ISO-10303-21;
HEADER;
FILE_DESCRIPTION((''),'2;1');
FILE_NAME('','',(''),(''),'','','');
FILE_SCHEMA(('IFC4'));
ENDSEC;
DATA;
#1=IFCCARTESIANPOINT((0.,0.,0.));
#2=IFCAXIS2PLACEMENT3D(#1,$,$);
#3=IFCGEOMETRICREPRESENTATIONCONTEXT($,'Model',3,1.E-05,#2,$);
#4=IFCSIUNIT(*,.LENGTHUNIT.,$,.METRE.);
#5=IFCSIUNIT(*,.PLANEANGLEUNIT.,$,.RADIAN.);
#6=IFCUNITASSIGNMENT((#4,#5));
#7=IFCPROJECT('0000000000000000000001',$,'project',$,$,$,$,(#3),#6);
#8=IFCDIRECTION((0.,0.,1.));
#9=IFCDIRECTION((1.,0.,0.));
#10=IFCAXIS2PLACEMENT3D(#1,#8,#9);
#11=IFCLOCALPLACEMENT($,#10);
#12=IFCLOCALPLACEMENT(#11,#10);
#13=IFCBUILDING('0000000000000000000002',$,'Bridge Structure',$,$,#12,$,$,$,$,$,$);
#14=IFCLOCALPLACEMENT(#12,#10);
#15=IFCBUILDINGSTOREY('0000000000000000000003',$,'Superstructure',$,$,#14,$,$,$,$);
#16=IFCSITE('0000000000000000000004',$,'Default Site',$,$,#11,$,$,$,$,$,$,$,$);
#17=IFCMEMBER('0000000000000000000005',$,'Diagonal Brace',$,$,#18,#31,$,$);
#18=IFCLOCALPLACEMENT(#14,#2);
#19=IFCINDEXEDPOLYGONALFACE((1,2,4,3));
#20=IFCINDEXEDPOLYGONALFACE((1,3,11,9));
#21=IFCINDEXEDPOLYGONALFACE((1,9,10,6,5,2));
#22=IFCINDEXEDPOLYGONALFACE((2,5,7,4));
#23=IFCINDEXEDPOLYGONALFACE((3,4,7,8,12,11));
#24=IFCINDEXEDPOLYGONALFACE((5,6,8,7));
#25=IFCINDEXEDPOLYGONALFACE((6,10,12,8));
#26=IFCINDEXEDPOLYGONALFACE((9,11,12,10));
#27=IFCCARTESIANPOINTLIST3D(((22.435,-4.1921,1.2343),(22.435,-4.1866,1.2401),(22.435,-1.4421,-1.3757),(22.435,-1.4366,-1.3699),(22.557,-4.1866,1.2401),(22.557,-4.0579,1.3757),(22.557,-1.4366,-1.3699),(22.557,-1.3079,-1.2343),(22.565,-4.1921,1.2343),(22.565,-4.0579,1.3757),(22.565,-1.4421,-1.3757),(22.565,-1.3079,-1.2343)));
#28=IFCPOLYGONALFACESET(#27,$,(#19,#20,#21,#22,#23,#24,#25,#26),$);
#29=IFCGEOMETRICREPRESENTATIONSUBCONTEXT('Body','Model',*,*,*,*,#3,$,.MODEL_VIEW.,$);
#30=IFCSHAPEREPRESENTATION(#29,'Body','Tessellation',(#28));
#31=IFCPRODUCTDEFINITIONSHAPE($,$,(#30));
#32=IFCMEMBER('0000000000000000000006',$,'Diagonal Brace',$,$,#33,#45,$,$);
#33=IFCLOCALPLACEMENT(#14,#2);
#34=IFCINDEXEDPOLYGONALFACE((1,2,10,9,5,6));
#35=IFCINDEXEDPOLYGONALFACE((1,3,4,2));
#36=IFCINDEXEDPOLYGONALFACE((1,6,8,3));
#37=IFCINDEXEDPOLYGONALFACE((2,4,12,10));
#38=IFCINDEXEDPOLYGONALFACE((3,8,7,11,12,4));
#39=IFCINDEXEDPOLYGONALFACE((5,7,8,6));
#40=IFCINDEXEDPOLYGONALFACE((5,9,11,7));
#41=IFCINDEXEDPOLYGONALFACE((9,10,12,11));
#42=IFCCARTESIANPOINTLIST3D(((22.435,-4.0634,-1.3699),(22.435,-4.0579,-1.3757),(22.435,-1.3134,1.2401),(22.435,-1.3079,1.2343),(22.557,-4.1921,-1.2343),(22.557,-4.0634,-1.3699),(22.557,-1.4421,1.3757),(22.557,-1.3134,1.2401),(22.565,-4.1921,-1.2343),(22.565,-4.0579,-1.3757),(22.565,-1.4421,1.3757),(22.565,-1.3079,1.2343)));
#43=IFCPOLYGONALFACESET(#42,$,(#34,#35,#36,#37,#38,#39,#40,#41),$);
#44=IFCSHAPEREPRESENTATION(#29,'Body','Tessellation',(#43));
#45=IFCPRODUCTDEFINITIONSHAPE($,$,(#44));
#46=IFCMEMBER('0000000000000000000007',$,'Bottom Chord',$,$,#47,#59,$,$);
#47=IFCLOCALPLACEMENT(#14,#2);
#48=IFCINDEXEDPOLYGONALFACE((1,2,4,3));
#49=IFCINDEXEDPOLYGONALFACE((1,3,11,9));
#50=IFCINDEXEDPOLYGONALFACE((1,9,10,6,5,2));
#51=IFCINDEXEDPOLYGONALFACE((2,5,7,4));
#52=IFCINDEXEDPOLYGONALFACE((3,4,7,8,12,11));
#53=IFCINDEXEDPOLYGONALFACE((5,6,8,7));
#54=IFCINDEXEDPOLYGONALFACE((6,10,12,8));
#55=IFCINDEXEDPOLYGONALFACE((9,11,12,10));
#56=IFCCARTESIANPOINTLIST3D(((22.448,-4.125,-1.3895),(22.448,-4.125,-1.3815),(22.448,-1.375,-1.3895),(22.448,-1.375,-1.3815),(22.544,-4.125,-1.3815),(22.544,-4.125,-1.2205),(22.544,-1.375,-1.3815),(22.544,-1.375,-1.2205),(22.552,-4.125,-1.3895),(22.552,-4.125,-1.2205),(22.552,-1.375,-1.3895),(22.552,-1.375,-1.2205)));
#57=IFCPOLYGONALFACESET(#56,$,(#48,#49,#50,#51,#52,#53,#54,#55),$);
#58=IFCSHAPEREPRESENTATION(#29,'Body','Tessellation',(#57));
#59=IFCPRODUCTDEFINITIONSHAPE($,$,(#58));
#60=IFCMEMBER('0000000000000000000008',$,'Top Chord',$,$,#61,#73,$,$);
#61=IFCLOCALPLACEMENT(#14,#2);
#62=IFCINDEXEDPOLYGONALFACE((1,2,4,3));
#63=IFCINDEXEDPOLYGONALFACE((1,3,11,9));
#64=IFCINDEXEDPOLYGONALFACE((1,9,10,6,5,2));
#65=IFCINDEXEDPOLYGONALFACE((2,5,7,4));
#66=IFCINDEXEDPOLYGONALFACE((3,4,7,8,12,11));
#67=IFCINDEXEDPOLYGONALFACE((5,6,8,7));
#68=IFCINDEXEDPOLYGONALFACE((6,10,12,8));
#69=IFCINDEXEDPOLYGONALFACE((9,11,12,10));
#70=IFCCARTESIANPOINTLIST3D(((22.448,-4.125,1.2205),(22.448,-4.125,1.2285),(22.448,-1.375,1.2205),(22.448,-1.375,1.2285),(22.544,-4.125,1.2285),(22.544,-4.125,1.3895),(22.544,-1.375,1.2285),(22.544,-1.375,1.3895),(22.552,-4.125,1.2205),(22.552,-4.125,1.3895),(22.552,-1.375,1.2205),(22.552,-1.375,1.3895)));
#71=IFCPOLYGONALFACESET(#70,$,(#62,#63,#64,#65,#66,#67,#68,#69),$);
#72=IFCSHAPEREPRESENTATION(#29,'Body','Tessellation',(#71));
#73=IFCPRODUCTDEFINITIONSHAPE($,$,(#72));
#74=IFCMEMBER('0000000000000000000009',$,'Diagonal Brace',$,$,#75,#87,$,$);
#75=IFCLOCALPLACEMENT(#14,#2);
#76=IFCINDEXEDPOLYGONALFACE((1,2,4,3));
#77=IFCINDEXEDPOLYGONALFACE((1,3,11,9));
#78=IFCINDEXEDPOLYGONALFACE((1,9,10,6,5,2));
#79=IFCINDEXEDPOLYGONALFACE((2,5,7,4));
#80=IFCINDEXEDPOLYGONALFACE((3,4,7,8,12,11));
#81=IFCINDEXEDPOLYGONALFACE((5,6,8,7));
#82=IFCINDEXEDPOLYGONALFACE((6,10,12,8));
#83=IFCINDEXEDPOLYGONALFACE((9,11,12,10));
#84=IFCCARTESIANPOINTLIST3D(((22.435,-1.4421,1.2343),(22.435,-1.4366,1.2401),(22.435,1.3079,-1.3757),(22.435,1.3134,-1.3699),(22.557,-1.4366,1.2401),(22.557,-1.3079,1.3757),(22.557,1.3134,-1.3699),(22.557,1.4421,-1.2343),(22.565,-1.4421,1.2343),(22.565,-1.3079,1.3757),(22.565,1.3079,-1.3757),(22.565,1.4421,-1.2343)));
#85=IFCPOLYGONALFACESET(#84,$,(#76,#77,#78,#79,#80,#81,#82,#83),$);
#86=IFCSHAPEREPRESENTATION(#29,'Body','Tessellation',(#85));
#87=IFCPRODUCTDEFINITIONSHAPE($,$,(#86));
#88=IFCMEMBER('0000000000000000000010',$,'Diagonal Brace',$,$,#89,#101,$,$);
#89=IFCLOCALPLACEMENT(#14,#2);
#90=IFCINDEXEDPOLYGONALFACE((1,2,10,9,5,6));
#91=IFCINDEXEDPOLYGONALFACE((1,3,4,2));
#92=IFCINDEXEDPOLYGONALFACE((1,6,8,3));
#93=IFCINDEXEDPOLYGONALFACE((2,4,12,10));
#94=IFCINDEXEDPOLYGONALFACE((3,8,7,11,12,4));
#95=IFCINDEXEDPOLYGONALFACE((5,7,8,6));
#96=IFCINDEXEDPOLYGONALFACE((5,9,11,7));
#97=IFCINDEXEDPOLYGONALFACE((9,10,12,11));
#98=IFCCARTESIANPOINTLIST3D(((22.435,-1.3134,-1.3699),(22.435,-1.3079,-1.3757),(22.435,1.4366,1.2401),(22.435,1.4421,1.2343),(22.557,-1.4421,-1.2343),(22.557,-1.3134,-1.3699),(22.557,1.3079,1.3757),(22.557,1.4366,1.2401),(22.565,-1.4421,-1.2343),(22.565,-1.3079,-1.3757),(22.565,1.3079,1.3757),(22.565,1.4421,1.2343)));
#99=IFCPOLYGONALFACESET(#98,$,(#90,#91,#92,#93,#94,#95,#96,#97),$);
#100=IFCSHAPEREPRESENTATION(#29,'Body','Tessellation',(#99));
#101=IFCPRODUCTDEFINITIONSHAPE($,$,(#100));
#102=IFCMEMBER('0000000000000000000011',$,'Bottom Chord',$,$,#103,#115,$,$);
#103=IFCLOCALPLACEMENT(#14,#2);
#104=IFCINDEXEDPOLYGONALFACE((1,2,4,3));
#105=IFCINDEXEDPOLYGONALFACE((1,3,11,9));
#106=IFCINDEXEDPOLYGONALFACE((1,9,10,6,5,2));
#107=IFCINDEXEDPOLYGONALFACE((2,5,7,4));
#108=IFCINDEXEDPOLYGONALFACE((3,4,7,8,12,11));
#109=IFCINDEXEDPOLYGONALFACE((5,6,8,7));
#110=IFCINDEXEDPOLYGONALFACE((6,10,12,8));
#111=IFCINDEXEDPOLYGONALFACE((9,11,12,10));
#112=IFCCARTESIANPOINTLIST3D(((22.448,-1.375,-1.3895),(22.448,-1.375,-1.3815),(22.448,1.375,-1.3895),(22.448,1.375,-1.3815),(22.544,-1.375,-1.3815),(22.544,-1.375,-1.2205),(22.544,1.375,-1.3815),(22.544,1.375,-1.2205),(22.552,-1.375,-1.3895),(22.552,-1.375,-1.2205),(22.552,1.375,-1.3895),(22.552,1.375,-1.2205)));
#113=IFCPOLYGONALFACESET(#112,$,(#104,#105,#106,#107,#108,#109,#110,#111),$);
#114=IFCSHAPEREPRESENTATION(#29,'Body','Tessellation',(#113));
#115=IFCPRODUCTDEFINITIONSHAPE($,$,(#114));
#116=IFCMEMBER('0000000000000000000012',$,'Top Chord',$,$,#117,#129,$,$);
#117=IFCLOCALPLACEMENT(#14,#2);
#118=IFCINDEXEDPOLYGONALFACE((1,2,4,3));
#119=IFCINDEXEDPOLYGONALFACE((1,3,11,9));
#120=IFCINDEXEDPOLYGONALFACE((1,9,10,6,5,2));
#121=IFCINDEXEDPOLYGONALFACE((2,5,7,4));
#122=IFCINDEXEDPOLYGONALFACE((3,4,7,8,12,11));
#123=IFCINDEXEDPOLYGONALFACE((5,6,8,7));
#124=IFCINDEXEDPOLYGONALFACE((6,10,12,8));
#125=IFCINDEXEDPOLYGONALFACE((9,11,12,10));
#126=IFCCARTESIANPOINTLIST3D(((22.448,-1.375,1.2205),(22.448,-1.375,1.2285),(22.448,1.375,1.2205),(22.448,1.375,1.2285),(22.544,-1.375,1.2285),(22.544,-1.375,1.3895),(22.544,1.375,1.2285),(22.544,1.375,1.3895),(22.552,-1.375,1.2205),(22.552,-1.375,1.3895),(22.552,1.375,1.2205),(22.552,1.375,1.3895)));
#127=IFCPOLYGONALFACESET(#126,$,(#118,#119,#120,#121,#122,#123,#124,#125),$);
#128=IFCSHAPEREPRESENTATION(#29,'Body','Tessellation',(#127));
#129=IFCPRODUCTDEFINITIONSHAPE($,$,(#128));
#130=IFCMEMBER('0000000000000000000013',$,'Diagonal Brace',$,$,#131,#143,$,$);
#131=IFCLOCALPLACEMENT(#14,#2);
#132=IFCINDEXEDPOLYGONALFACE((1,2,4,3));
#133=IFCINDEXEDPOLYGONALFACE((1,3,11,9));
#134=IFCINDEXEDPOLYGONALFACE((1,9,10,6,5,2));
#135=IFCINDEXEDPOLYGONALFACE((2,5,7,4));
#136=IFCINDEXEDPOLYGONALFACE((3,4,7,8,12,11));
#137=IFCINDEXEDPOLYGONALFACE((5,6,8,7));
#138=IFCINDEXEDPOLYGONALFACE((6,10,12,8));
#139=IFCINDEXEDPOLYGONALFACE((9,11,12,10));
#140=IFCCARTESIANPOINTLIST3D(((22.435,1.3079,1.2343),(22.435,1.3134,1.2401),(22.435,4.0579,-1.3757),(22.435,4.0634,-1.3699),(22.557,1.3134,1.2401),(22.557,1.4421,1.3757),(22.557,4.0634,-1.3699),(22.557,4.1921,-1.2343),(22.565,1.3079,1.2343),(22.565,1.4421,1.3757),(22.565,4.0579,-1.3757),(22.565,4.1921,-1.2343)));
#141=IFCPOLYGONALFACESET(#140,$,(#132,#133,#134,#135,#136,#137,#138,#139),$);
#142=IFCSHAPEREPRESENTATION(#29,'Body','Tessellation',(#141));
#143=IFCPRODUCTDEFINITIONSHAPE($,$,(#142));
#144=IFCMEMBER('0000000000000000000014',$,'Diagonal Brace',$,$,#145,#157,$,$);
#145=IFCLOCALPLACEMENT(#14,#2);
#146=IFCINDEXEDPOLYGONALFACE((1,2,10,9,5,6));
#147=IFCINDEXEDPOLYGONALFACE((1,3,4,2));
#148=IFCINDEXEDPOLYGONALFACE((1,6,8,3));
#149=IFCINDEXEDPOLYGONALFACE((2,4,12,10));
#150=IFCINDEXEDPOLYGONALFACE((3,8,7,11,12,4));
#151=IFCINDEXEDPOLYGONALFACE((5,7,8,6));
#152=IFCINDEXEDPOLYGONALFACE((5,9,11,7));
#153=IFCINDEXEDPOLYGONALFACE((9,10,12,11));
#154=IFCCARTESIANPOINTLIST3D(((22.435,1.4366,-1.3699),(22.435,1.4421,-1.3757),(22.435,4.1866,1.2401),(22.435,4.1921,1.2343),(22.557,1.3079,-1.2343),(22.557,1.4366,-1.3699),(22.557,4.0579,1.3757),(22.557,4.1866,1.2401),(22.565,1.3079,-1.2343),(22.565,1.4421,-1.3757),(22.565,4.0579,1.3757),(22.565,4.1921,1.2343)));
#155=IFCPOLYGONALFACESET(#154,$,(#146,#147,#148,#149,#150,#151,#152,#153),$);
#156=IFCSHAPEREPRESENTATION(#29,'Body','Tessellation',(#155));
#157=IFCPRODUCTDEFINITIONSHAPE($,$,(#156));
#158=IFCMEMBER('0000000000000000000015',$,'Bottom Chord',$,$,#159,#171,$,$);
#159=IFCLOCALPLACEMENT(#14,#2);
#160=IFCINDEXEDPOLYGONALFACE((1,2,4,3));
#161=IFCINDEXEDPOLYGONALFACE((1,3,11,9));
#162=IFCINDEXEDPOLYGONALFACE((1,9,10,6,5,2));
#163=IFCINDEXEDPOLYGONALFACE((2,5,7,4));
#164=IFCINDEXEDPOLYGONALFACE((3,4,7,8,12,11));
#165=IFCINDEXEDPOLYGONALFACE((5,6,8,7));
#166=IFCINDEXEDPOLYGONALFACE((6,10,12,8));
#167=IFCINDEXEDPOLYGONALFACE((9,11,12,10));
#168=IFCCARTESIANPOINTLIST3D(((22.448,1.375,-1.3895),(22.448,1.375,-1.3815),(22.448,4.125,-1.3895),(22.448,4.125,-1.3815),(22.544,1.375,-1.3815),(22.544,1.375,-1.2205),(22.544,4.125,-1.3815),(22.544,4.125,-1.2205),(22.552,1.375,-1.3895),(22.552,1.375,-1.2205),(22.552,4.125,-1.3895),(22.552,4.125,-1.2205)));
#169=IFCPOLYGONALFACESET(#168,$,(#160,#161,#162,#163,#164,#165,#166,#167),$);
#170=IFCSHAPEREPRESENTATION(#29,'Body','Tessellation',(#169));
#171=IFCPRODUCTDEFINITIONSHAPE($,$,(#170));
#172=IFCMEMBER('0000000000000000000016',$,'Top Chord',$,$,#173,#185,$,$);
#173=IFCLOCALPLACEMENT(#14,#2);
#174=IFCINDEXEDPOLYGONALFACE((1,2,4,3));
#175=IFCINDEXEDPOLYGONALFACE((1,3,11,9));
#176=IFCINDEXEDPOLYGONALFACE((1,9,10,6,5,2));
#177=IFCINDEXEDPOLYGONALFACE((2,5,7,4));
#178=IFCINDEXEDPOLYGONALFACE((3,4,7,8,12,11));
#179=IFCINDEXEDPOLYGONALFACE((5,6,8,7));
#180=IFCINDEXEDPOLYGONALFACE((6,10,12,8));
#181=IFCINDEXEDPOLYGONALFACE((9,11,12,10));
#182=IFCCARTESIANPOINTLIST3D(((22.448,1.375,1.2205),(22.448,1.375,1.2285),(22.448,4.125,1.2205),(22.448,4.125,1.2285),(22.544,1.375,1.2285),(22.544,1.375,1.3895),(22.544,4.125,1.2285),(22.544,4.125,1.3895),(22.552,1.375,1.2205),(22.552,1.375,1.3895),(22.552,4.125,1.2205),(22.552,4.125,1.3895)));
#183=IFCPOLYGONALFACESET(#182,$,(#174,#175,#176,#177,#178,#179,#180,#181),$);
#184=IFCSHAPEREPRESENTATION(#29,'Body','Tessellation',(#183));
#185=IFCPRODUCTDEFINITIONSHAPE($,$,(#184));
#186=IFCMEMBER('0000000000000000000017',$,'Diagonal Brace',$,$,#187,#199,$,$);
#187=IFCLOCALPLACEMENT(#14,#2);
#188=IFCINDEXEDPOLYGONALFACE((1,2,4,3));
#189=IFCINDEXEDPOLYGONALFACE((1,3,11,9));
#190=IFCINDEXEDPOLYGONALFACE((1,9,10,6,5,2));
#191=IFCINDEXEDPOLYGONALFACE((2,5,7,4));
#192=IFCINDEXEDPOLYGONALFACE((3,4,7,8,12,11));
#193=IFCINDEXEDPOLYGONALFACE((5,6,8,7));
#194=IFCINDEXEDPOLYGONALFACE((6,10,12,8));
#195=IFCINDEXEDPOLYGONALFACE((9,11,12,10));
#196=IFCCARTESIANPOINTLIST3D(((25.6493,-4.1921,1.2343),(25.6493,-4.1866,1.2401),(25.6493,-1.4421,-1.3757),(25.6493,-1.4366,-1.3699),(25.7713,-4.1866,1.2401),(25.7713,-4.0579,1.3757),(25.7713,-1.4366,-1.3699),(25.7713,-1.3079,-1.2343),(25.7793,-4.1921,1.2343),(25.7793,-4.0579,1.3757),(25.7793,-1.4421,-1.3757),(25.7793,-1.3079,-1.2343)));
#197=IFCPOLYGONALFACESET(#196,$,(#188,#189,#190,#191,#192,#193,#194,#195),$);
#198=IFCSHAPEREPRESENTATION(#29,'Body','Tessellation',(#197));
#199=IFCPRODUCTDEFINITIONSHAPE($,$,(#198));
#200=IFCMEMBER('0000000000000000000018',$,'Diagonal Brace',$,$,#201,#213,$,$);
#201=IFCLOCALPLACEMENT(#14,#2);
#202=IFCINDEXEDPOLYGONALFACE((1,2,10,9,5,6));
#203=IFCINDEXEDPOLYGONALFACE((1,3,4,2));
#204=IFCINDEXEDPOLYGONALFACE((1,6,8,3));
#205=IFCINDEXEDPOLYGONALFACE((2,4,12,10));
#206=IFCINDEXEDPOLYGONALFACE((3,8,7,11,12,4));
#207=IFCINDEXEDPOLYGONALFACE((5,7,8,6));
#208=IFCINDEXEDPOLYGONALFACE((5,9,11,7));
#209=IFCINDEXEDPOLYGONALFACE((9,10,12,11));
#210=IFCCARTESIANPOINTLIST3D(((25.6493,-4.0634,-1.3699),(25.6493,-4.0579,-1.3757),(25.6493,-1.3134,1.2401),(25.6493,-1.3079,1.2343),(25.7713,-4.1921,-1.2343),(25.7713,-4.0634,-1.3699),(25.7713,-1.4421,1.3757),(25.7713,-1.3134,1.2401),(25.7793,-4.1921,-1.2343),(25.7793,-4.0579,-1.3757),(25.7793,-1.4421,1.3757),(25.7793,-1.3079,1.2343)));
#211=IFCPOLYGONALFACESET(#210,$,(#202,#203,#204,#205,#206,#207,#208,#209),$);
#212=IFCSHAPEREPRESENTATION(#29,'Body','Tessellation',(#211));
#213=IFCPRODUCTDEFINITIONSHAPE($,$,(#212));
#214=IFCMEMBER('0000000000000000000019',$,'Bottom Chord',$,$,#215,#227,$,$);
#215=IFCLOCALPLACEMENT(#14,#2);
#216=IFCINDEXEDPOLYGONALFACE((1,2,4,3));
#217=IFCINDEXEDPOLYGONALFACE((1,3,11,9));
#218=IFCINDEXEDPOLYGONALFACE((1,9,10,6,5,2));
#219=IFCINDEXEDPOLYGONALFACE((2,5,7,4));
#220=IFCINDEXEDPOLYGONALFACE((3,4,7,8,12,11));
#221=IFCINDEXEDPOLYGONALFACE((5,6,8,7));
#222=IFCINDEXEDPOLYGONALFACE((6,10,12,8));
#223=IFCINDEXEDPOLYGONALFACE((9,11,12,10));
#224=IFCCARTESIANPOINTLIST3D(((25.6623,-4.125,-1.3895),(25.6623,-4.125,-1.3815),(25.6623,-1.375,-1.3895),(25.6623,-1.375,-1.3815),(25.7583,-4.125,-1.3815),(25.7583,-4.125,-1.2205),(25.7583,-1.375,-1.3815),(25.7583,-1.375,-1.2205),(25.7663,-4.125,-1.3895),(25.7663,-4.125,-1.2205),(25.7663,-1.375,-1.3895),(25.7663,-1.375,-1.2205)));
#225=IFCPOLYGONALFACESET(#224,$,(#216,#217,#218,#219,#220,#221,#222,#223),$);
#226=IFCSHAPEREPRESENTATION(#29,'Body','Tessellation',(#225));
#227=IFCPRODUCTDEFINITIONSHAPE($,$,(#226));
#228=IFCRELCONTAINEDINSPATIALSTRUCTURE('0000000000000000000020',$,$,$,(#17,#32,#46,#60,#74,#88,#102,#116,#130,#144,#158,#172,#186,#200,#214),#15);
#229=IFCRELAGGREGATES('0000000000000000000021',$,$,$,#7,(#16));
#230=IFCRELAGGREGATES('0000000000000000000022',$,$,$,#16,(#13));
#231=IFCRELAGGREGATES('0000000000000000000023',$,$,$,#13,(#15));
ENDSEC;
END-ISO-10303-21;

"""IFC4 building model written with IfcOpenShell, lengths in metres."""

from ifc_helpers import new_model, si_unit, frame, origin, origin_with_axes, origin_2d_with_axis, place, context, subcontext, project, spatial, l_section, extrude, element, save


model = new_model("IFC4")

# Units and contexts
model_context = context("Model", 3, precision=1e-05, world=origin())
body_context = subcontext(model_context, "Body", "Model", "MODEL_VIEW")
ifc_project = project(units=[si_unit("LENGTHUNIT", "METRE"), si_unit("PLANEANGLEUNIT", "RADIAN")], contexts=[model_context])

# Site, building, storey
site_placement = place(None, origin_with_axes())
site = spatial("IfcSite", under=ifc_project, at=site_placement, Name="Default Site")
building_placement = place(site_placement, origin_with_axes())
building = spatial("IfcBuilding", under=site, at=building_placement, Name="Bridge Structure")
storey_placement = place(building_placement, origin_with_axes())
storey = spatial("IfcBuildingStorey", under=building, at=storey_placement, Name="Superstructure")

# Members
for number, where, z_axis, x_axis, name in (
    (1, (22.5, -4.125, 1.305), (0.0, 0.725329, -0.688403), (-1.0, 0.0, 0.0), "Diagonal Brace"),
    (2, (22.5, -4.125, -1.305), (0.0, 0.725329, 0.688403), (-1.0, 0.0, 0.0), "Diagonal Brace"),
):
    element("IfcMember", number, at=place(storey_placement, frame(where, z_axis=z_axis, x_axis=x_axis)), inside=storey, Name=name, context=body_context, shape_type="SweptSolid", body=[
        extrude(l_section(Depth=0.195, Width=0.13, Thickness=0.008, at=origin_2d_with_axis()), origin_with_axes(), (0.0, 0.0, 1.0), 3.7914),
    ])
for number, where, z_axis, x_axis, name in (
    (3, (22.5, -4.125, -1.305), (0.0, 1.0, 0.0), (-1.0, 0.0, 0.0), "Bottom Chord"),
    (4, (22.5, -4.125, 1.305), (0.0, 1.0, 0.0), (-1.0, 0.0, 0.0), "Top Chord"),
):
    element("IfcMember", number, at=place(storey_placement, frame(where, z_axis=z_axis, x_axis=x_axis)), inside=storey, Name=name, context=body_context, shape_type="SweptSolid", body=[
        extrude(l_section(Depth=0.169, Width=0.104, Thickness=0.008, at=origin_2d_with_axis()), origin_with_axes(), (0.0, 0.0, 1.0), 2.75),
    ])
for number, where, z_axis, x_axis, name in (
    (5, (22.5, -1.375, 1.305), (0.0, 0.725329, -0.688403), (-1.0, 0.0, 0.0), "Diagonal Brace"),
    (6, (22.5, -1.375, -1.305), (0.0, 0.725329, 0.688403), (-1.0, 0.0, 0.0), "Diagonal Brace"),
):
    element("IfcMember", number, at=place(storey_placement, frame(where, z_axis=z_axis, x_axis=x_axis)), inside=storey, Name=name, context=body_context, shape_type="SweptSolid", body=[
        extrude(l_section(Depth=0.195, Width=0.13, Thickness=0.008, at=origin_2d_with_axis()), origin_with_axes(), (0.0, 0.0, 1.0), 3.7914),
    ])
for number, where, z_axis, x_axis, name in (
    (7, (22.5, -1.375, -1.305), (0.0, 1.0, 0.0), (-1.0, 0.0, 0.0), "Bottom Chord"),
    (8, (22.5, -1.375, 1.305), (0.0, 1.0, 0.0), (-1.0, 0.0, 0.0), "Top Chord"),
):
    element("IfcMember", number, at=place(storey_placement, frame(where, z_axis=z_axis, x_axis=x_axis)), inside=storey, Name=name, context=body_context, shape_type="SweptSolid", body=[
        extrude(l_section(Depth=0.169, Width=0.104, Thickness=0.008, at=origin_2d_with_axis()), origin_with_axes(), (0.0, 0.0, 1.0), 2.75),
    ])
for number, where, z_axis, x_axis, name in (
    (9, (22.5, 1.375, 1.305), (0.0, 0.725329, -0.688403), (-1.0, 0.0, 0.0), "Diagonal Brace"),
    (10, (22.5, 1.375, -1.305), (0.0, 0.725329, 0.688403), (-1.0, 0.0, 0.0), "Diagonal Brace"),
):
    element("IfcMember", number, at=place(storey_placement, frame(where, z_axis=z_axis, x_axis=x_axis)), inside=storey, Name=name, context=body_context, shape_type="SweptSolid", body=[
        extrude(l_section(Depth=0.195, Width=0.13, Thickness=0.008, at=origin_2d_with_axis()), origin_with_axes(), (0.0, 0.0, 1.0), 3.7914),
    ])
for number, where, z_axis, x_axis, name in (
    (11, (22.5, 1.375, -1.305), (0.0, 1.0, 0.0), (-1.0, 0.0, 0.0), "Bottom Chord"),
    (12, (22.5, 1.375, 1.305), (0.0, 1.0, 0.0), (-1.0, 0.0, 0.0), "Top Chord"),
):
    element("IfcMember", number, at=place(storey_placement, frame(where, z_axis=z_axis, x_axis=x_axis)), inside=storey, Name=name, context=body_context, shape_type="SweptSolid", body=[
        extrude(l_section(Depth=0.169, Width=0.104, Thickness=0.008, at=origin_2d_with_axis()), origin_with_axes(), (0.0, 0.0, 1.0), 2.75),
    ])
for number, where, z_axis, x_axis, name in (
    (13, (25.7143, -4.125, 1.305), (0.0, 0.725329, -0.688403), (-1.0, 0.0, 0.0), "Diagonal Brace"),
    (14, (25.7143, -4.125, -1.305), (0.0, 0.725329, 0.688403), (-1.0, 0.0, 0.0), "Diagonal Brace"),
):
    element("IfcMember", number, at=place(storey_placement, frame(where, z_axis=z_axis, x_axis=x_axis)), inside=storey, Name=name, context=body_context, shape_type="SweptSolid", body=[
        extrude(l_section(Depth=0.195, Width=0.13, Thickness=0.008, at=origin_2d_with_axis()), origin_with_axes(), (0.0, 0.0, 1.0), 3.7914),
    ])
for number, where, z_axis, x_axis, name in (
    (15, (25.7143, -4.125, -1.305), (0.0, 1.0, 0.0), (-1.0, 0.0, 0.0), "Bottom Chord"),
):
    element("IfcMember", number, at=place(storey_placement, frame(where, z_axis=z_axis, x_axis=x_axis)), inside=storey, Name=name, context=body_context, shape_type="SweptSolid", body=[
        extrude(l_section(Depth=0.169, Width=0.104, Thickness=0.008, at=origin_2d_with_axis()), origin_with_axes(), (0.0, 0.0, 1.0), 2.75),
    ])

save(model, "model.ifc")
